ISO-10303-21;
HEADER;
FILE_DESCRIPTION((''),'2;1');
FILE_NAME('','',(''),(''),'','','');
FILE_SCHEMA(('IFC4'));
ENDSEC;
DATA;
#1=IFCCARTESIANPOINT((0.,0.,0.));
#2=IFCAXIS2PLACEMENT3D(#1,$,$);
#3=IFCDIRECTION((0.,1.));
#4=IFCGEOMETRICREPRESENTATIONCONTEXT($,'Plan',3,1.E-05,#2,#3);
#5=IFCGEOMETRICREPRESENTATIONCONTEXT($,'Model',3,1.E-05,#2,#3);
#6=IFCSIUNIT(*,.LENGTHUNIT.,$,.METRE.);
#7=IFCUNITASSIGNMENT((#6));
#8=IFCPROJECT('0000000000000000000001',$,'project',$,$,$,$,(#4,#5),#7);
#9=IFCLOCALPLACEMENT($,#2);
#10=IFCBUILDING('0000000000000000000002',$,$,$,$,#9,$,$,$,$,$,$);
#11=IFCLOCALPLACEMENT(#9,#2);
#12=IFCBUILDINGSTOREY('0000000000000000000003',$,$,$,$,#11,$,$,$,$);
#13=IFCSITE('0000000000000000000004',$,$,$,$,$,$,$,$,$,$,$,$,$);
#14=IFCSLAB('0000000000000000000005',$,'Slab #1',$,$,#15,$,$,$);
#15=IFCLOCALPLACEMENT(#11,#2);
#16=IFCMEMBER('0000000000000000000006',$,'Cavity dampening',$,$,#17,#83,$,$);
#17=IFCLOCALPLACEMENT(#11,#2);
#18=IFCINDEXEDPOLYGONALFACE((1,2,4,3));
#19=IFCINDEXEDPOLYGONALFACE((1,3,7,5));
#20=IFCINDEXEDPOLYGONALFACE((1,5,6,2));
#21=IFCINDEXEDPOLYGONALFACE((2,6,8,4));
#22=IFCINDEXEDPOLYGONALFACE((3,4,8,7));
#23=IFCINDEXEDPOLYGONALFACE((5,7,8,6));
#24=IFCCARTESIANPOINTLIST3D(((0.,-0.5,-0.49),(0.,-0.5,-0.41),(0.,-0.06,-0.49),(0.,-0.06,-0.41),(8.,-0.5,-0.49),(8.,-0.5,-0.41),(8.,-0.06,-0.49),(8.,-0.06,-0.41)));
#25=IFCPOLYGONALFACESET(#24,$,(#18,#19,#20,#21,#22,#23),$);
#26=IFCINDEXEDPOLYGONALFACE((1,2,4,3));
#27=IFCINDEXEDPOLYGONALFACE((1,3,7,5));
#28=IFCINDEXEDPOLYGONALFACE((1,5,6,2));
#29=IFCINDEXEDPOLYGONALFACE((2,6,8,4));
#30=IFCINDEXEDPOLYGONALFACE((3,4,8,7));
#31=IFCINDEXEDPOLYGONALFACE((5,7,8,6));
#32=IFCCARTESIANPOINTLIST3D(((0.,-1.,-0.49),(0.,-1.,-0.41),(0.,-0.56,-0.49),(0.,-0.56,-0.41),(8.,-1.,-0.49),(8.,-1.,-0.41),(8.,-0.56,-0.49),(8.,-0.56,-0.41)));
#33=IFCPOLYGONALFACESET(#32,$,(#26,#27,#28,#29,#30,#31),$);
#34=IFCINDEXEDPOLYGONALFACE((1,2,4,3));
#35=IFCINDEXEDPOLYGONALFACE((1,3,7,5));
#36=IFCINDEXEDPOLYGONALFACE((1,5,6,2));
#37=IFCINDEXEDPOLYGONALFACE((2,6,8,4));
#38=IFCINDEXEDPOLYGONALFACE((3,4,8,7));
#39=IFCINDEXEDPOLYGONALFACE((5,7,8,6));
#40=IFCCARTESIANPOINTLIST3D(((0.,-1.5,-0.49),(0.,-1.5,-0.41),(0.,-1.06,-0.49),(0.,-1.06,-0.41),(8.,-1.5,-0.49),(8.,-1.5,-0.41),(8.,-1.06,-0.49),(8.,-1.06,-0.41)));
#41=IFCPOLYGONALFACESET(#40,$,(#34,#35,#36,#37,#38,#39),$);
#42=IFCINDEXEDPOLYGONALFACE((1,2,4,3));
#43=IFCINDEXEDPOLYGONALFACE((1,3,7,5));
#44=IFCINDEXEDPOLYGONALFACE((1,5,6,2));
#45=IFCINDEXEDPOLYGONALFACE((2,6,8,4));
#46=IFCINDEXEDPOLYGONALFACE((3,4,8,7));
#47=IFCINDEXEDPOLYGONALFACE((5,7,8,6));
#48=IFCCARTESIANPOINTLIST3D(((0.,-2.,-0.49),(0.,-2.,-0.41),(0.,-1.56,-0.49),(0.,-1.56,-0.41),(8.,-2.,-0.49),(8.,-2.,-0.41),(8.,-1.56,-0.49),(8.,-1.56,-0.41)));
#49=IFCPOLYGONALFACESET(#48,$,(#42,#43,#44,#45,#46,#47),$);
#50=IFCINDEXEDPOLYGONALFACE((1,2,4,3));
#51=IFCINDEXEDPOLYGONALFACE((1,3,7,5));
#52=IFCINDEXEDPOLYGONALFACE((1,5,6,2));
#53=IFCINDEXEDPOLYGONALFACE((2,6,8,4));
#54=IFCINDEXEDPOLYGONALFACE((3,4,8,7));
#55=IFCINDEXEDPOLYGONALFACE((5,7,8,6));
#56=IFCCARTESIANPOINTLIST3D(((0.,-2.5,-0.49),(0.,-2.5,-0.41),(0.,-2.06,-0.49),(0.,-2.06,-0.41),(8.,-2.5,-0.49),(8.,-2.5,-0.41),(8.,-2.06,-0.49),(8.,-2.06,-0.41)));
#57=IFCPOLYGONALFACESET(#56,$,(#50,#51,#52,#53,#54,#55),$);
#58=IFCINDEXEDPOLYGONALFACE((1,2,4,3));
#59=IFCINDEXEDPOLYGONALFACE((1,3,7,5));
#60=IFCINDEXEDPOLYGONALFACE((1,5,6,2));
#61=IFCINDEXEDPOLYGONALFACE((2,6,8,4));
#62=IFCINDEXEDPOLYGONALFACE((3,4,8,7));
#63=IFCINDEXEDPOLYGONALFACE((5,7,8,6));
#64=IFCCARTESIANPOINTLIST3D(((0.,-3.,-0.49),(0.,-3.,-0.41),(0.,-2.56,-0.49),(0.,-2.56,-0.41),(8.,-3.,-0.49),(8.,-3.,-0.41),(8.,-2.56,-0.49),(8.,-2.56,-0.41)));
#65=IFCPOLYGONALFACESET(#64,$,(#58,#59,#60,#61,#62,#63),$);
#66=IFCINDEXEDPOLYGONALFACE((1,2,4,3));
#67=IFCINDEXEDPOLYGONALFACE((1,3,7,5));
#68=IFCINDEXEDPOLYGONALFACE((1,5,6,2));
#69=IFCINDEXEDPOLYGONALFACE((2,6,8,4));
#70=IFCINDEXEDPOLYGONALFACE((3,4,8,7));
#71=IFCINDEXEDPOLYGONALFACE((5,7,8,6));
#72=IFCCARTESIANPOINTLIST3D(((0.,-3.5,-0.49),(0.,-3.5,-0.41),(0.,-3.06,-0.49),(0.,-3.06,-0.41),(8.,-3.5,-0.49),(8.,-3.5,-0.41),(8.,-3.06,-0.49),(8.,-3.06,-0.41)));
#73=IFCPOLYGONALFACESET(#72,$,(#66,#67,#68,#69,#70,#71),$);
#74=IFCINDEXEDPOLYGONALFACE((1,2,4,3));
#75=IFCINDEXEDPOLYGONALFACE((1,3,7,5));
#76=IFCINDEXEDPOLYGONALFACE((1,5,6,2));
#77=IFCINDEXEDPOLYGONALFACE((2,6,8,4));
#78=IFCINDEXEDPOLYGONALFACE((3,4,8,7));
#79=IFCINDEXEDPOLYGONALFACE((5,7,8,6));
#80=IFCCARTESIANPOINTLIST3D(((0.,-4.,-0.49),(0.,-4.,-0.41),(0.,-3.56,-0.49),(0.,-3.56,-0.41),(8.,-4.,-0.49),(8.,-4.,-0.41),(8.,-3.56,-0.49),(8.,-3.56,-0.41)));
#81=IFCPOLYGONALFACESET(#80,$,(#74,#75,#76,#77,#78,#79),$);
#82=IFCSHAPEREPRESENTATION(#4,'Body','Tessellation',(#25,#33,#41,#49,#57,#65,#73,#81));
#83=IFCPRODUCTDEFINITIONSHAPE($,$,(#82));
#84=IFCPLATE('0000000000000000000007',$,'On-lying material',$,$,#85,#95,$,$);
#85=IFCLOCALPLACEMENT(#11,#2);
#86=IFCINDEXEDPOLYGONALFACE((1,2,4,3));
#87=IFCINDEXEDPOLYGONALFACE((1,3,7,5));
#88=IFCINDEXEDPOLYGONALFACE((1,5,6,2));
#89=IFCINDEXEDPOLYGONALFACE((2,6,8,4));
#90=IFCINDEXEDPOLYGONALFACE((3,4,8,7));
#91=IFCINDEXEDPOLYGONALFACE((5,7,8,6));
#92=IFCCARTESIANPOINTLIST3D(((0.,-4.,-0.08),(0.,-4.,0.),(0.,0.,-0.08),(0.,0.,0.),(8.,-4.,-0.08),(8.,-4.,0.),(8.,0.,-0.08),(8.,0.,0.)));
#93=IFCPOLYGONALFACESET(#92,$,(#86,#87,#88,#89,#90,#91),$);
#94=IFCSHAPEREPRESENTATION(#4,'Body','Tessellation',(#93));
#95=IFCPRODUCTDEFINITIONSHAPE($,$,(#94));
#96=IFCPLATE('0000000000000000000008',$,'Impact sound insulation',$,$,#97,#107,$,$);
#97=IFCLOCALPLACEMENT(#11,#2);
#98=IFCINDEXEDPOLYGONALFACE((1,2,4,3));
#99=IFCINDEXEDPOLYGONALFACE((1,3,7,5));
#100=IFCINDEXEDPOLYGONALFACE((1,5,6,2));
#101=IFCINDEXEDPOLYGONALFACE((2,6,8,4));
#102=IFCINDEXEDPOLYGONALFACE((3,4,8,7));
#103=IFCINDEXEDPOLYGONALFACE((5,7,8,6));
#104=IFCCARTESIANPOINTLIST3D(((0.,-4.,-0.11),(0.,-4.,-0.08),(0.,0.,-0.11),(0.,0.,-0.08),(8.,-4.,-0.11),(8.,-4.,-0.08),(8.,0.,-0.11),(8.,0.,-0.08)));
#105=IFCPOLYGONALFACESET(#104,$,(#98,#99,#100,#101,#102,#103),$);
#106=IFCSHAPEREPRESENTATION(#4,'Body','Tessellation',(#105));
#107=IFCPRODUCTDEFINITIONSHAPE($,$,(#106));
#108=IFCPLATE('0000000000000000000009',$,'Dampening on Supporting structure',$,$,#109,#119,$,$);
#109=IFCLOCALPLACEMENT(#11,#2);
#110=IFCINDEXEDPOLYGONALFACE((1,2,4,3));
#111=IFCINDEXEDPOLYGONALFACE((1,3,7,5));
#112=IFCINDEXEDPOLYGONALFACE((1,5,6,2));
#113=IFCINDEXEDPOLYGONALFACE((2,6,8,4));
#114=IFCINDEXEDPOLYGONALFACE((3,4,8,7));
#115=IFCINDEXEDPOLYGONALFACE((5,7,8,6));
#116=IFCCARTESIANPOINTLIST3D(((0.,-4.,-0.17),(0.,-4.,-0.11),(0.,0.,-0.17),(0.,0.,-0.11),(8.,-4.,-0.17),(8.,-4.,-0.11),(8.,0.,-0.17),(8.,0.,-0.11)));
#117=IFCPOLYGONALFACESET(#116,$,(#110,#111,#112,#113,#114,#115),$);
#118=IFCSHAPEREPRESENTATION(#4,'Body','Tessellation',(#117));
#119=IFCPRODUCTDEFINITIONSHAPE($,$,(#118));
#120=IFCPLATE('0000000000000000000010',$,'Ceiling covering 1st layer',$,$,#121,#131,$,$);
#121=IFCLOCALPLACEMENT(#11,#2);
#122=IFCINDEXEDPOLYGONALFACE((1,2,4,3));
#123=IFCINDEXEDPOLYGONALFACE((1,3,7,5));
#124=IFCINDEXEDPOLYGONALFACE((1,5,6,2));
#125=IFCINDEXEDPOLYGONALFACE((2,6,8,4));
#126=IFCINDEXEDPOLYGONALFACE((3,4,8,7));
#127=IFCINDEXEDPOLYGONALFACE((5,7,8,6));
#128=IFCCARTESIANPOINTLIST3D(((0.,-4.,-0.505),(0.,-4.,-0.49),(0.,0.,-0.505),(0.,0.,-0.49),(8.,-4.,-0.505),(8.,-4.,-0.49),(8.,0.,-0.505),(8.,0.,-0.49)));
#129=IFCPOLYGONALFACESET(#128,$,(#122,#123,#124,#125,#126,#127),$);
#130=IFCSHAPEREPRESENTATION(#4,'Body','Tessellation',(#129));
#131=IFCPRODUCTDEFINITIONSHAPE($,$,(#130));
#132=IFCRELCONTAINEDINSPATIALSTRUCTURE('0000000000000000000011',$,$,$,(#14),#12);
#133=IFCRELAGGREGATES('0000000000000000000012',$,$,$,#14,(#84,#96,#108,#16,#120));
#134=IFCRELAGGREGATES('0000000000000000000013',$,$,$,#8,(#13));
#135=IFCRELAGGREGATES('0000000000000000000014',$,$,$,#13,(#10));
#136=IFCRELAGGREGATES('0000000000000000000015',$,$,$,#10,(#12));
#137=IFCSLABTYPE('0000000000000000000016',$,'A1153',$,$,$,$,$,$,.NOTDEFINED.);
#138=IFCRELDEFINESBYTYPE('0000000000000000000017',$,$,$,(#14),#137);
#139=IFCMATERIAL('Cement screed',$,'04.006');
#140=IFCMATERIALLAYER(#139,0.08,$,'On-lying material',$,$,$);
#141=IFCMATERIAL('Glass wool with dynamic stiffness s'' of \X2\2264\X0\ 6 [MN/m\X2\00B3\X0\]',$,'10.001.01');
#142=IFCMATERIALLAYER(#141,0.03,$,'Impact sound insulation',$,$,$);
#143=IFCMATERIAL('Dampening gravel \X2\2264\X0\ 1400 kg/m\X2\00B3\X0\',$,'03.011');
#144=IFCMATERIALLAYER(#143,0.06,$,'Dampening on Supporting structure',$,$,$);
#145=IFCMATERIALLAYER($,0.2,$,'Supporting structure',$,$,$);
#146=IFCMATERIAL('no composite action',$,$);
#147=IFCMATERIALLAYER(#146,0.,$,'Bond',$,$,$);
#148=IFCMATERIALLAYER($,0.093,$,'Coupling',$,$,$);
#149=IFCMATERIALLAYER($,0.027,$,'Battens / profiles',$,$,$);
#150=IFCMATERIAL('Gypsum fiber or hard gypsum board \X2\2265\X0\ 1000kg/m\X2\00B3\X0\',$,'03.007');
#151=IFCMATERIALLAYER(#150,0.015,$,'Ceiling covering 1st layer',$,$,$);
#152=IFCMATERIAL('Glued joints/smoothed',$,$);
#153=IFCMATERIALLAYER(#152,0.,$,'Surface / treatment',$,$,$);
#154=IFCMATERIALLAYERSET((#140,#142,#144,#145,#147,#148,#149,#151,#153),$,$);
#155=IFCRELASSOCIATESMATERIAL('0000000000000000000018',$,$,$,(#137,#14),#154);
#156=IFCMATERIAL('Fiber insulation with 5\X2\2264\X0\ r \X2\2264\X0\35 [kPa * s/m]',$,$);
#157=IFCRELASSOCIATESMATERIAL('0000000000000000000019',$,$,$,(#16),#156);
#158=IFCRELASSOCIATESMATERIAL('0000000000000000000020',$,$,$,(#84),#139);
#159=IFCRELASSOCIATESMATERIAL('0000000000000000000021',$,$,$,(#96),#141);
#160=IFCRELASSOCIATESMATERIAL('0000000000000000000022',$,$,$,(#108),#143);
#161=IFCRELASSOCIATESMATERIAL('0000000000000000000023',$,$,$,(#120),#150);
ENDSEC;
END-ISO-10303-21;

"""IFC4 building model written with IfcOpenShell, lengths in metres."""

from ifc_helpers import new_model, si_unit, direction, frame, frame_2d, origin, origin_with_axes, place, context, project, spatial, rectangle, extrude, material, layer, layer_set, type_object, element, aggregate, save


model = new_model("IFC4")

# Units and contexts
plan_context = context("Plan", 3, precision=1e-05, world=origin(), true_north=direction((0.0, 1.0)))
model_context = context("Model", 3, precision=1e-05, world=origin(), true_north=direction((0.0, 1.0)))
ifc_project = project(units=[si_unit("LENGTHUNIT", "METRE")], contexts=[plan_context, model_context])

# Site, building, storey
site = spatial("IfcSite", under=ifc_project)
building_placement = place(None, origin())
building = spatial("IfcBuilding", under=site, at=building_placement)
storey_placement = place(building_placement, origin())
storey = spatial("IfcBuildingStorey", under=building, at=storey_placement)

# Slab, member, plates
ifc_material_1 = material(Name="Cement screed", Category="04.006")
ifc_layer_1 = layer(ifc_material_1, 0.08, Name="On-lying material")
ifc_material_2 = material(Name="Glass wool with dynamic stiffness s' of ≤ 6 [MN/m³]", Category="10.001.01")
ifc_layer_2 = layer(ifc_material_2, 0.03, Name="Impact sound insulation")
ifc_material_3 = material(Name="Dampening gravel ≤ 1400 kg/m³", Category="03.011")
ifc_layer_3 = layer(ifc_material_3, 0.06, Name="Dampening on Supporting structure")
ifc_layer_4 = layer(None, 0.2, Name="Supporting structure")
ifc_material_4 = material(Name="no composite action")
ifc_layer_5 = layer(ifc_material_4, 0.0, Name="Bond")
ifc_layer_6 = layer(None, 0.093, Name="Coupling")
ifc_layer_7 = layer(None, 0.027, Name="Battens / profiles")
ifc_material_5 = material(Name="Gypsum fiber or hard gypsum board ≥ 1000kg/m³", Category="03.007")
ifc_layer_8 = layer(ifc_material_5, 0.015, Name="Ceiling covering 1st layer")
ifc_material_6 = material(Name="Glued joints/smoothed")
ifc_layer_9 = layer(ifc_material_6, 0.0, Name="Surface / treatment")
ifc_layer_set = layer_set([ifc_layer_1, ifc_layer_2, ifc_layer_3, ifc_layer_4, ifc_layer_5, ifc_layer_6, ifc_layer_7, ifc_layer_8, ifc_layer_9])
slab_type = type_object("IfcSlabType", Name="A1153", PredefinedType="NOTDEFINED", material=ifc_layer_set)
slab_placement = place(None, frame((0.0, 0.0, 0.0), z_axis=(0.0, 0.0, -1.0), x_axis=(1.0, 0.0, 0.0)))
slab = element("IfcSlab", 1, at=slab_placement, inside=storey, type_object=slab_type, material=ifc_layer_set, Name="Slab #1")
ifc_material_7 = material(Name="Fiber insulation with 5≤ r ≤35 [kPa * s/m]")
member_1_placement = place(slab_placement, origin())
member_1 = element("IfcMember", 2, at=member_1_placement, material=ifc_material_7, Name="Cavity dampening", context=plan_context, shape_type="SweptSolid", body=[
    extrude(rectangle(XDim=0.44, YDim=0.08, at=frame_2d((0.22, 0.04), x_axis=(1.0, 0.0))), frame((0.0, 0.06, 0.41), z_axis=(1.0, 0.0, 0.0), x_axis=(0.0, 1.0, 0.0)), (0.0, 0.0, 1.0), 8.0),
    extrude(rectangle(XDim=0.44, YDim=0.08, at=frame_2d((0.22, 0.04), x_axis=(1.0, 0.0))), frame((0.0, 0.56, 0.41), z_axis=(1.0, 0.0, 0.0), x_axis=(0.0, 1.0, 0.0)), (0.0, 0.0, 1.0), 8.0),
    extrude(rectangle(XDim=0.44, YDim=0.08, at=frame_2d((0.22, 0.04), x_axis=(1.0, 0.0))), frame((0.0, 1.06, 0.41), z_axis=(1.0, 0.0, 0.0), x_axis=(0.0, 1.0, 0.0)), (0.0, 0.0, 1.0), 8.0),
    extrude(rectangle(XDim=0.44, YDim=0.08, at=frame_2d((0.22, 0.04), x_axis=(1.0, 0.0))), frame((0.0, 1.56, 0.41), z_axis=(1.0, 0.0, 0.0), x_axis=(0.0, 1.0, 0.0)), (0.0, 0.0, 1.0), 8.0),
    extrude(rectangle(XDim=0.44, YDim=0.08, at=frame_2d((0.22, 0.04), x_axis=(1.0, 0.0))), frame((0.0, 2.06, 0.41), z_axis=(1.0, 0.0, 0.0), x_axis=(0.0, 1.0, 0.0)), (0.0, 0.0, 1.0), 8.0),
    extrude(rectangle(XDim=0.44, YDim=0.08, at=frame_2d((0.22, 0.04), x_axis=(1.0, 0.0))), frame((0.0, 2.56, 0.41), z_axis=(1.0, 0.0, 0.0), x_axis=(0.0, 1.0, 0.0)), (0.0, 0.0, 1.0), 8.0),
    extrude(rectangle(XDim=0.44, YDim=0.08, at=frame_2d((0.22, 0.04), x_axis=(1.0, 0.0))), frame((0.0, 3.06, 0.41), z_axis=(1.0, 0.0, 0.0), x_axis=(0.0, 1.0, 0.0)), (0.0, 0.0, 1.0), 8.0),
    extrude(rectangle(XDim=0.44, YDim=0.08, at=frame_2d((0.22, 0.04), x_axis=(1.0, 0.0))), frame((0.0, 3.56, 0.41), z_axis=(1.0, 0.0, 0.0), x_axis=(0.0, 1.0, 0.0)), (0.0, 0.0, 1.0), 8.0),
])
plate_1_placement = place(slab_placement, origin())
plate_1 = element("IfcPlate", 3, at=plate_1_placement, material=ifc_material_1, Name="On-lying material", context=plan_context, shape_type="SweptSolid", body=[
    extrude(rectangle(XDim=8.0, YDim=4.0, at=frame_2d((4.0, 2.0), x_axis=(1.0, 0.0))), origin_with_axes(), (0.0, 0.0, 1.0), 0.08),
])
plate_2_placement = place(slab_placement, origin())
plate_2 = element("IfcPlate", 4, at=plate_2_placement, material=ifc_material_2, Name="Impact sound insulation", context=plan_context, shape_type="SweptSolid", body=[
    extrude(rectangle(XDim=8.0, YDim=4.0, at=frame_2d((4.0, 2.0), x_axis=(1.0, 0.0))), frame((0.0, 0.0, 0.08), z_axis=(0.0, 0.0, 1.0), x_axis=(1.0, 0.0, 0.0)), (0.0, 0.0, 1.0), 0.03),
])
plate_3_placement = place(slab_placement, origin())
plate_3 = element("IfcPlate", 5, at=plate_3_placement, material=ifc_material_3, Name="Dampening on Supporting structure", context=plan_context, shape_type="SweptSolid", body=[
    extrude(rectangle(XDim=8.0, YDim=4.0, at=frame_2d((4.0, 2.0), x_axis=(1.0, 0.0))), frame((0.0, 0.0, 0.11), z_axis=(0.0, 0.0, 1.0), x_axis=(1.0, 0.0, 0.0)), (0.0, 0.0, 1.0), 0.06),
])
plate_4_placement = place(slab_placement, origin())
plate_4 = element("IfcPlate", 6, at=plate_4_placement, material=ifc_material_5, Name="Ceiling covering 1st layer", context=plan_context, shape_type="SweptSolid", body=[
    extrude(rectangle(XDim=8.0, YDim=4.0, at=frame_2d((4.0, 2.0), x_axis=(1.0, 0.0))), frame((0.0, 0.0, 0.49), z_axis=(0.0, 0.0, 1.0), x_axis=(1.0, 0.0, 0.0)), (0.0, 0.0, 1.0), 0.015),
])
aggregate(slab, [plate_1, plate_2, plate_3, member_1, plate_4])

save(model, "model.ifc")
